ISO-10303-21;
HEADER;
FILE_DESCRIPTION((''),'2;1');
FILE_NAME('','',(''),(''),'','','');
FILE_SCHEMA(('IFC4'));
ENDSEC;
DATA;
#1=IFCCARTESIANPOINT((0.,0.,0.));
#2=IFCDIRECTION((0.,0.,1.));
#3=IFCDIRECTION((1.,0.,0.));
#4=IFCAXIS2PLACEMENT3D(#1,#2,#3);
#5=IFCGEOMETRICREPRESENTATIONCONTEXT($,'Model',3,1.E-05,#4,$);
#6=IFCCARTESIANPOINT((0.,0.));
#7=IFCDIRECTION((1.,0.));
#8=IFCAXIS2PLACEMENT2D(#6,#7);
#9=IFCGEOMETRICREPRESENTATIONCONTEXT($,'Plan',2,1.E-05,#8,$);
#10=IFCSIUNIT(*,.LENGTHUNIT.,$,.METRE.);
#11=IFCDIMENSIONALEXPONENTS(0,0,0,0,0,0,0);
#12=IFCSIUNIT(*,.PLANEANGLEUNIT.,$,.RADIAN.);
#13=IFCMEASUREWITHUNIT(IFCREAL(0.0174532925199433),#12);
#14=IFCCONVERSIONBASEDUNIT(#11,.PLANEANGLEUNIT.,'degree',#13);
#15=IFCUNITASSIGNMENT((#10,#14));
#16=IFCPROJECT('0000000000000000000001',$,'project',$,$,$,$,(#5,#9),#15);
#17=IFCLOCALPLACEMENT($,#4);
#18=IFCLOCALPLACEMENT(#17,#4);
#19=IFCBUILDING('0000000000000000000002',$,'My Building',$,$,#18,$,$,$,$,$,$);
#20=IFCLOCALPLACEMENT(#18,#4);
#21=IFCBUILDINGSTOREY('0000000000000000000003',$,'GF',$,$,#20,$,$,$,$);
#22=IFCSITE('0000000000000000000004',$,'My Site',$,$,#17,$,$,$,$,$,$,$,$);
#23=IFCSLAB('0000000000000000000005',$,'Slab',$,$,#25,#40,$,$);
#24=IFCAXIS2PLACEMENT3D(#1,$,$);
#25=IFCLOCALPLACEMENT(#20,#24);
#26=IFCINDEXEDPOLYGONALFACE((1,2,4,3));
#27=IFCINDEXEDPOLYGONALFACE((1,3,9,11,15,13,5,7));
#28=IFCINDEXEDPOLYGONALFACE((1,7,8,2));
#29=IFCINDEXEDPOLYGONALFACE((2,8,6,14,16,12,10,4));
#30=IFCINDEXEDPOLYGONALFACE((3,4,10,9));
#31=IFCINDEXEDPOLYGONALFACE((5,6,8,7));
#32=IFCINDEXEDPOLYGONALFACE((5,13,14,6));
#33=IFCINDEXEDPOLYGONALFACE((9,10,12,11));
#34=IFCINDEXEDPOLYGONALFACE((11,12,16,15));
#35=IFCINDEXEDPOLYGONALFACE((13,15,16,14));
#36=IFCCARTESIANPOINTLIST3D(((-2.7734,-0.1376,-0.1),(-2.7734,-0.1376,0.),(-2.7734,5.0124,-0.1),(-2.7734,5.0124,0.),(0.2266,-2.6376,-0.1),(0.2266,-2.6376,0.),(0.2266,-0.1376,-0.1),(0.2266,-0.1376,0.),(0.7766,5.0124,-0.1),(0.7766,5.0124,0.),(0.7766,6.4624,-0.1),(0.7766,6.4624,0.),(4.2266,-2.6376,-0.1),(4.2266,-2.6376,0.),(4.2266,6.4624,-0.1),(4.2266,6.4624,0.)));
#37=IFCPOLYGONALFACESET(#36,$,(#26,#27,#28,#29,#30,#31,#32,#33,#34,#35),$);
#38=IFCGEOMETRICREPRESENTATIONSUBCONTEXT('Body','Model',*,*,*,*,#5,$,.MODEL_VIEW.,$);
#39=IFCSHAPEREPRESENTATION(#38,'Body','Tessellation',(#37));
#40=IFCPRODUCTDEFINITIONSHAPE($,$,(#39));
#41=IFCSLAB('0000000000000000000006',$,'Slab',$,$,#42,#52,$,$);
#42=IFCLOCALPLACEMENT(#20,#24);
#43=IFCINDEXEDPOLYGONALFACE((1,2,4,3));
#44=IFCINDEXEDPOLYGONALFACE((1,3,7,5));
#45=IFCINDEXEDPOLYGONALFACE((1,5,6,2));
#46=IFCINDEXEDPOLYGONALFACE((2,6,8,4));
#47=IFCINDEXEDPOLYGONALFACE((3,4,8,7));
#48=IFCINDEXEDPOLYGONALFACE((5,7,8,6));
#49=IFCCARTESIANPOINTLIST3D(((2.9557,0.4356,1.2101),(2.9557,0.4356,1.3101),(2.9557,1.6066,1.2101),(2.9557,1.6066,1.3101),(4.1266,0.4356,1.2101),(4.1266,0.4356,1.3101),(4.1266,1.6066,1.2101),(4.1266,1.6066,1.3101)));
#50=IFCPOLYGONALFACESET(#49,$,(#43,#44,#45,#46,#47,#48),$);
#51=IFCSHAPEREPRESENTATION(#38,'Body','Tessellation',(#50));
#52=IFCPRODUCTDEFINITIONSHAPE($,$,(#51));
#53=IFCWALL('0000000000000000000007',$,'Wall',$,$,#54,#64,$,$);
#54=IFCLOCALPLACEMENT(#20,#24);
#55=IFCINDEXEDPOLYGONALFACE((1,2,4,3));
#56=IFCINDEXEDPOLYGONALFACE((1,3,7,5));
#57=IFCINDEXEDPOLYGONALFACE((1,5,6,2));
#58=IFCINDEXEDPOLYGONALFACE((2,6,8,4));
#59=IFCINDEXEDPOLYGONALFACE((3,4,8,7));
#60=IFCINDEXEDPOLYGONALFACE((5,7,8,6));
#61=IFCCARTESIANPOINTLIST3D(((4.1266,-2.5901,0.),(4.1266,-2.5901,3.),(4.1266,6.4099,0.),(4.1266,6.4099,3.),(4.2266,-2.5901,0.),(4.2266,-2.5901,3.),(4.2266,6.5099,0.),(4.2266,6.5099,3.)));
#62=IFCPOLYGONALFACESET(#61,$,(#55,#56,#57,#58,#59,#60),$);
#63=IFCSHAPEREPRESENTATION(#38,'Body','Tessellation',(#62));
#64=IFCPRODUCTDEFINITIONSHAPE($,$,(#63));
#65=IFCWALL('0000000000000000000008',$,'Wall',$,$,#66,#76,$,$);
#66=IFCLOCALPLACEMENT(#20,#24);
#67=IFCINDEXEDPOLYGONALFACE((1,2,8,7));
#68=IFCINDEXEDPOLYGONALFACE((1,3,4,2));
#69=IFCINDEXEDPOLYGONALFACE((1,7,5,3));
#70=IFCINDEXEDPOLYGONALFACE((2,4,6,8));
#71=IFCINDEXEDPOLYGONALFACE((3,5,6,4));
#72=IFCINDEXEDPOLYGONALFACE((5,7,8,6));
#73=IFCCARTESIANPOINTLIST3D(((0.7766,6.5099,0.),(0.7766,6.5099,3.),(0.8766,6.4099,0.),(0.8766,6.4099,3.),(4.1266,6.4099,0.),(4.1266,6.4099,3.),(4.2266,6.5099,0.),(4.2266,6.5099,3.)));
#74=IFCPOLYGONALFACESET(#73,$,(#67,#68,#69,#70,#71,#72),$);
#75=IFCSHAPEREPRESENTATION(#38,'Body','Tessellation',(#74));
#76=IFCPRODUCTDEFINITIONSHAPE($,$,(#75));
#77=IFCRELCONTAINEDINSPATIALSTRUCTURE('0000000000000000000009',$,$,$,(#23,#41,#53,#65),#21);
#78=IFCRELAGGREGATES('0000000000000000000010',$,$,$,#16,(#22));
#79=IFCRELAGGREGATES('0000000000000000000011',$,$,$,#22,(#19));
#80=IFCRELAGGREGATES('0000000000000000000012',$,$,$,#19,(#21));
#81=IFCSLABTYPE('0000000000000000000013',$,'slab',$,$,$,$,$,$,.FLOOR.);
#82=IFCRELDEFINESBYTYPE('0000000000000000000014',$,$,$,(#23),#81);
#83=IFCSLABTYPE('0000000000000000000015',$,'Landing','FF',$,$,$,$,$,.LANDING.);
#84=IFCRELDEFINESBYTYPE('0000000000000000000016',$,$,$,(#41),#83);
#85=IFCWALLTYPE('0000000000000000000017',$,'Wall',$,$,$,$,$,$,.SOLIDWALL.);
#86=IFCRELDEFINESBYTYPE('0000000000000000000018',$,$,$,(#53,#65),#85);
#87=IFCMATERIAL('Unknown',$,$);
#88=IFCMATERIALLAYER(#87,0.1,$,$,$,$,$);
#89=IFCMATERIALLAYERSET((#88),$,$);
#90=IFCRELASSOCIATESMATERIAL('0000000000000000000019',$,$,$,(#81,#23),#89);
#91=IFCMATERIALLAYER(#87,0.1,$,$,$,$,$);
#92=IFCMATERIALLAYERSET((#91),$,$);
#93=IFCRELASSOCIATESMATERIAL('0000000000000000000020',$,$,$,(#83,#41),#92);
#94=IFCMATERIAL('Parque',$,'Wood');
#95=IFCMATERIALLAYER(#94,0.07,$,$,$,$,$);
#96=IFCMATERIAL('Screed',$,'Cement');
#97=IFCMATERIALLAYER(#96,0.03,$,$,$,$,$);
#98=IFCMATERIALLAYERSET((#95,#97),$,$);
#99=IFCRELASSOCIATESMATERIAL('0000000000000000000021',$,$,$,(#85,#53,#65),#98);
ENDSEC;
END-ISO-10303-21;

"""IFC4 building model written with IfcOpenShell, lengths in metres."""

from ifc_helpers import new_model, entity, si_unit, converted_unit, frame, origin_with_axes, origin_2d_with_axis, place, context, subcontext, project, spatial, line, indexed_curve, outline, extrude, material, layer, layer_set, layer_usage, type_object, element, save


model = new_model("IFC4")

# Units and contexts
model_context = context("Model", 3, precision=1e-05, world=origin_with_axes())
plan_context = context("Plan", 2, precision=1e-05, world=origin_2d_with_axis())
body_context_1 = subcontext(model_context, "Body", "Model", "MODEL_VIEW")
ifc_project = project(units=[si_unit("LENGTHUNIT", "METRE"), converted_unit("PLANEANGLEUNIT", "degree", entity("IfcReal", 0.0174532925199433), si_unit("PLANEANGLEUNIT", "RADIAN"), dimensions=[0, 0, 0, 0, 0, 0, 0])], contexts=[model_context, plan_context])

# Site, building, storey
site_placement = place(None, origin_with_axes())
site = spatial("IfcSite", under=ifc_project, at=site_placement, Name="My Site")
building_placement = place(site_placement, origin_with_axes())
building = spatial("IfcBuilding", under=site, at=building_placement, Name="My Building")
storey_placement = place(building_placement, origin_with_axes())
storey = spatial("IfcBuildingStorey", under=building, at=storey_placement, Name="GF")

# Slabs
ifc_material_1 = material(Name="Unknown")
ifc_layer_1 = layer(ifc_material_1, 0.1)
ifc_layer_set_1 = layer_set([ifc_layer_1])
ifc_layer_usage_1 = layer_usage(ifc_layer_set_1, "AXIS3", "POSITIVE", -0.1)
slab_type_1 = type_object("IfcSlabType", Name="slab", PredefinedType="FLOOR", material=ifc_layer_set_1)
slab_1_placement = place(storey_placement, frame((4.2266, -2.6376, 0.0), z_axis=(0.0, 0.0, 1.0), x_axis=(1.0, 0.0, 0.0)))
element("IfcSlab", 1, at=slab_1_placement, inside=storey, type_object=slab_type_1, material=ifc_layer_usage_1, Name="Slab", context=body_context_1, shape_type="SweptSolid", body=[
    extrude(outline(indexed_curve([(0.0, 0.0), (0.0, 9.1), (-3.45, 9.1), (-3.45, 7.65), (-7.0, 7.65), (-7.0, 2.5), (-4.0, 2.5), (-4.0, 0.0), (0.0, 0.0)])), frame((0.0, 0.0, -0.1), z_axis=(0.0, 0.0, 1.0), x_axis=(1.0, 0.0, 0.0)), (0.0, 0.0, 1.0), 0.1),
])
ifc_layer_2 = layer(ifc_material_1, 0.1)
ifc_layer_set_2 = layer_set([ifc_layer_2])
ifc_layer_usage_2 = layer_usage(ifc_layer_set_2, "AXIS3", "POSITIVE", -0.1)
slab_type_2 = type_object("IfcSlabType", Name="Landing", Description="FF", PredefinedType="LANDING", material=ifc_layer_set_2)
slab_2_placement = place(storey_placement, frame((4.1266, 0.4356, 1.3101), z_axis=(0.0, 0.0, 1.0), x_axis=(1.0, 0.0, 0.0)))
element("IfcSlab", 2, at=slab_2_placement, inside=storey, type_object=slab_type_2, material=ifc_layer_usage_2, Name="Slab", context=body_context_1, shape_type="SweptSolid", body=[
    extrude(outline(indexed_curve([(0.0, 0.0), (-1.1709, 0.0), (-1.1709, 1.171), (0.0, 1.171), (0.0, 0.0)])), frame((0.0, 0.0, -0.1), z_axis=(0.0, 0.0, 1.0), x_axis=(1.0, 0.0, 0.0)), (0.0, 0.0, 1.0), 0.1),
])

# Shared definitions
ifc_material_2 = material(Name="Parque", Category="Wood")
ifc_layer_3 = layer(ifc_material_2, 0.07)
ifc_material_3 = material(Name="Screed", Category="Cement")
ifc_layer_4 = layer(ifc_material_3, 0.03)
ifc_layer_set_3 = layer_set([ifc_layer_3, ifc_layer_4])
wall_type = type_object("IfcWallType", Name="Wall", PredefinedType="SOLIDWALL", material=ifc_layer_set_3)

# Walls
ifc_layer_usage_3 = layer_usage(ifc_layer_set_3, "AXIS2", "POSITIVE", 0.0)
wall_1_placement = place(storey_placement, frame((4.2266, -2.5901, 0.0), z_axis=(0.0, 0.0, 1.0), x_axis=(0.0, 1.0, 0.0)))
element("IfcWall", 3, at=wall_1_placement, inside=storey, type_object=wall_type, material=ifc_layer_usage_3, Name="Wall", context=body_context_1, shape_type="SweptSolid", body=[
    extrude(outline(indexed_curve([(0.0, 0.0), (0.0, 0.1), (9.0, 0.1), (9.1, 0.0)], segments=[line(1, 2, 3, 4, 1)])), origin_with_axes(), (0.0, 0.0, 1.0), 3.0),
])
ifc_layer_usage_4 = layer_usage(ifc_layer_set_3, "AXIS2", "POSITIVE", 0.0)
wall_2_placement = place(storey_placement, frame((4.2266, 6.5099, 0.0), z_axis=(0.0, 0.0, 1.0), x_axis=(-1.0, 0.0, 0.0)))
element("IfcWall", 4, at=wall_2_placement, inside=storey, type_object=wall_type, material=ifc_layer_usage_4, Name="Wall", context=body_context_1, shape_type="SweptSolid", body=[
    extrude(outline(indexed_curve([(0.0, 0.0), (0.1, 0.1), (3.35, 0.1), (3.45, 0.0)], segments=[line(1, 2, 3, 4, 1)])), origin_with_axes(), (0.0, 0.0, 1.0), 3.0),
])

save(model, "model.ifc")
